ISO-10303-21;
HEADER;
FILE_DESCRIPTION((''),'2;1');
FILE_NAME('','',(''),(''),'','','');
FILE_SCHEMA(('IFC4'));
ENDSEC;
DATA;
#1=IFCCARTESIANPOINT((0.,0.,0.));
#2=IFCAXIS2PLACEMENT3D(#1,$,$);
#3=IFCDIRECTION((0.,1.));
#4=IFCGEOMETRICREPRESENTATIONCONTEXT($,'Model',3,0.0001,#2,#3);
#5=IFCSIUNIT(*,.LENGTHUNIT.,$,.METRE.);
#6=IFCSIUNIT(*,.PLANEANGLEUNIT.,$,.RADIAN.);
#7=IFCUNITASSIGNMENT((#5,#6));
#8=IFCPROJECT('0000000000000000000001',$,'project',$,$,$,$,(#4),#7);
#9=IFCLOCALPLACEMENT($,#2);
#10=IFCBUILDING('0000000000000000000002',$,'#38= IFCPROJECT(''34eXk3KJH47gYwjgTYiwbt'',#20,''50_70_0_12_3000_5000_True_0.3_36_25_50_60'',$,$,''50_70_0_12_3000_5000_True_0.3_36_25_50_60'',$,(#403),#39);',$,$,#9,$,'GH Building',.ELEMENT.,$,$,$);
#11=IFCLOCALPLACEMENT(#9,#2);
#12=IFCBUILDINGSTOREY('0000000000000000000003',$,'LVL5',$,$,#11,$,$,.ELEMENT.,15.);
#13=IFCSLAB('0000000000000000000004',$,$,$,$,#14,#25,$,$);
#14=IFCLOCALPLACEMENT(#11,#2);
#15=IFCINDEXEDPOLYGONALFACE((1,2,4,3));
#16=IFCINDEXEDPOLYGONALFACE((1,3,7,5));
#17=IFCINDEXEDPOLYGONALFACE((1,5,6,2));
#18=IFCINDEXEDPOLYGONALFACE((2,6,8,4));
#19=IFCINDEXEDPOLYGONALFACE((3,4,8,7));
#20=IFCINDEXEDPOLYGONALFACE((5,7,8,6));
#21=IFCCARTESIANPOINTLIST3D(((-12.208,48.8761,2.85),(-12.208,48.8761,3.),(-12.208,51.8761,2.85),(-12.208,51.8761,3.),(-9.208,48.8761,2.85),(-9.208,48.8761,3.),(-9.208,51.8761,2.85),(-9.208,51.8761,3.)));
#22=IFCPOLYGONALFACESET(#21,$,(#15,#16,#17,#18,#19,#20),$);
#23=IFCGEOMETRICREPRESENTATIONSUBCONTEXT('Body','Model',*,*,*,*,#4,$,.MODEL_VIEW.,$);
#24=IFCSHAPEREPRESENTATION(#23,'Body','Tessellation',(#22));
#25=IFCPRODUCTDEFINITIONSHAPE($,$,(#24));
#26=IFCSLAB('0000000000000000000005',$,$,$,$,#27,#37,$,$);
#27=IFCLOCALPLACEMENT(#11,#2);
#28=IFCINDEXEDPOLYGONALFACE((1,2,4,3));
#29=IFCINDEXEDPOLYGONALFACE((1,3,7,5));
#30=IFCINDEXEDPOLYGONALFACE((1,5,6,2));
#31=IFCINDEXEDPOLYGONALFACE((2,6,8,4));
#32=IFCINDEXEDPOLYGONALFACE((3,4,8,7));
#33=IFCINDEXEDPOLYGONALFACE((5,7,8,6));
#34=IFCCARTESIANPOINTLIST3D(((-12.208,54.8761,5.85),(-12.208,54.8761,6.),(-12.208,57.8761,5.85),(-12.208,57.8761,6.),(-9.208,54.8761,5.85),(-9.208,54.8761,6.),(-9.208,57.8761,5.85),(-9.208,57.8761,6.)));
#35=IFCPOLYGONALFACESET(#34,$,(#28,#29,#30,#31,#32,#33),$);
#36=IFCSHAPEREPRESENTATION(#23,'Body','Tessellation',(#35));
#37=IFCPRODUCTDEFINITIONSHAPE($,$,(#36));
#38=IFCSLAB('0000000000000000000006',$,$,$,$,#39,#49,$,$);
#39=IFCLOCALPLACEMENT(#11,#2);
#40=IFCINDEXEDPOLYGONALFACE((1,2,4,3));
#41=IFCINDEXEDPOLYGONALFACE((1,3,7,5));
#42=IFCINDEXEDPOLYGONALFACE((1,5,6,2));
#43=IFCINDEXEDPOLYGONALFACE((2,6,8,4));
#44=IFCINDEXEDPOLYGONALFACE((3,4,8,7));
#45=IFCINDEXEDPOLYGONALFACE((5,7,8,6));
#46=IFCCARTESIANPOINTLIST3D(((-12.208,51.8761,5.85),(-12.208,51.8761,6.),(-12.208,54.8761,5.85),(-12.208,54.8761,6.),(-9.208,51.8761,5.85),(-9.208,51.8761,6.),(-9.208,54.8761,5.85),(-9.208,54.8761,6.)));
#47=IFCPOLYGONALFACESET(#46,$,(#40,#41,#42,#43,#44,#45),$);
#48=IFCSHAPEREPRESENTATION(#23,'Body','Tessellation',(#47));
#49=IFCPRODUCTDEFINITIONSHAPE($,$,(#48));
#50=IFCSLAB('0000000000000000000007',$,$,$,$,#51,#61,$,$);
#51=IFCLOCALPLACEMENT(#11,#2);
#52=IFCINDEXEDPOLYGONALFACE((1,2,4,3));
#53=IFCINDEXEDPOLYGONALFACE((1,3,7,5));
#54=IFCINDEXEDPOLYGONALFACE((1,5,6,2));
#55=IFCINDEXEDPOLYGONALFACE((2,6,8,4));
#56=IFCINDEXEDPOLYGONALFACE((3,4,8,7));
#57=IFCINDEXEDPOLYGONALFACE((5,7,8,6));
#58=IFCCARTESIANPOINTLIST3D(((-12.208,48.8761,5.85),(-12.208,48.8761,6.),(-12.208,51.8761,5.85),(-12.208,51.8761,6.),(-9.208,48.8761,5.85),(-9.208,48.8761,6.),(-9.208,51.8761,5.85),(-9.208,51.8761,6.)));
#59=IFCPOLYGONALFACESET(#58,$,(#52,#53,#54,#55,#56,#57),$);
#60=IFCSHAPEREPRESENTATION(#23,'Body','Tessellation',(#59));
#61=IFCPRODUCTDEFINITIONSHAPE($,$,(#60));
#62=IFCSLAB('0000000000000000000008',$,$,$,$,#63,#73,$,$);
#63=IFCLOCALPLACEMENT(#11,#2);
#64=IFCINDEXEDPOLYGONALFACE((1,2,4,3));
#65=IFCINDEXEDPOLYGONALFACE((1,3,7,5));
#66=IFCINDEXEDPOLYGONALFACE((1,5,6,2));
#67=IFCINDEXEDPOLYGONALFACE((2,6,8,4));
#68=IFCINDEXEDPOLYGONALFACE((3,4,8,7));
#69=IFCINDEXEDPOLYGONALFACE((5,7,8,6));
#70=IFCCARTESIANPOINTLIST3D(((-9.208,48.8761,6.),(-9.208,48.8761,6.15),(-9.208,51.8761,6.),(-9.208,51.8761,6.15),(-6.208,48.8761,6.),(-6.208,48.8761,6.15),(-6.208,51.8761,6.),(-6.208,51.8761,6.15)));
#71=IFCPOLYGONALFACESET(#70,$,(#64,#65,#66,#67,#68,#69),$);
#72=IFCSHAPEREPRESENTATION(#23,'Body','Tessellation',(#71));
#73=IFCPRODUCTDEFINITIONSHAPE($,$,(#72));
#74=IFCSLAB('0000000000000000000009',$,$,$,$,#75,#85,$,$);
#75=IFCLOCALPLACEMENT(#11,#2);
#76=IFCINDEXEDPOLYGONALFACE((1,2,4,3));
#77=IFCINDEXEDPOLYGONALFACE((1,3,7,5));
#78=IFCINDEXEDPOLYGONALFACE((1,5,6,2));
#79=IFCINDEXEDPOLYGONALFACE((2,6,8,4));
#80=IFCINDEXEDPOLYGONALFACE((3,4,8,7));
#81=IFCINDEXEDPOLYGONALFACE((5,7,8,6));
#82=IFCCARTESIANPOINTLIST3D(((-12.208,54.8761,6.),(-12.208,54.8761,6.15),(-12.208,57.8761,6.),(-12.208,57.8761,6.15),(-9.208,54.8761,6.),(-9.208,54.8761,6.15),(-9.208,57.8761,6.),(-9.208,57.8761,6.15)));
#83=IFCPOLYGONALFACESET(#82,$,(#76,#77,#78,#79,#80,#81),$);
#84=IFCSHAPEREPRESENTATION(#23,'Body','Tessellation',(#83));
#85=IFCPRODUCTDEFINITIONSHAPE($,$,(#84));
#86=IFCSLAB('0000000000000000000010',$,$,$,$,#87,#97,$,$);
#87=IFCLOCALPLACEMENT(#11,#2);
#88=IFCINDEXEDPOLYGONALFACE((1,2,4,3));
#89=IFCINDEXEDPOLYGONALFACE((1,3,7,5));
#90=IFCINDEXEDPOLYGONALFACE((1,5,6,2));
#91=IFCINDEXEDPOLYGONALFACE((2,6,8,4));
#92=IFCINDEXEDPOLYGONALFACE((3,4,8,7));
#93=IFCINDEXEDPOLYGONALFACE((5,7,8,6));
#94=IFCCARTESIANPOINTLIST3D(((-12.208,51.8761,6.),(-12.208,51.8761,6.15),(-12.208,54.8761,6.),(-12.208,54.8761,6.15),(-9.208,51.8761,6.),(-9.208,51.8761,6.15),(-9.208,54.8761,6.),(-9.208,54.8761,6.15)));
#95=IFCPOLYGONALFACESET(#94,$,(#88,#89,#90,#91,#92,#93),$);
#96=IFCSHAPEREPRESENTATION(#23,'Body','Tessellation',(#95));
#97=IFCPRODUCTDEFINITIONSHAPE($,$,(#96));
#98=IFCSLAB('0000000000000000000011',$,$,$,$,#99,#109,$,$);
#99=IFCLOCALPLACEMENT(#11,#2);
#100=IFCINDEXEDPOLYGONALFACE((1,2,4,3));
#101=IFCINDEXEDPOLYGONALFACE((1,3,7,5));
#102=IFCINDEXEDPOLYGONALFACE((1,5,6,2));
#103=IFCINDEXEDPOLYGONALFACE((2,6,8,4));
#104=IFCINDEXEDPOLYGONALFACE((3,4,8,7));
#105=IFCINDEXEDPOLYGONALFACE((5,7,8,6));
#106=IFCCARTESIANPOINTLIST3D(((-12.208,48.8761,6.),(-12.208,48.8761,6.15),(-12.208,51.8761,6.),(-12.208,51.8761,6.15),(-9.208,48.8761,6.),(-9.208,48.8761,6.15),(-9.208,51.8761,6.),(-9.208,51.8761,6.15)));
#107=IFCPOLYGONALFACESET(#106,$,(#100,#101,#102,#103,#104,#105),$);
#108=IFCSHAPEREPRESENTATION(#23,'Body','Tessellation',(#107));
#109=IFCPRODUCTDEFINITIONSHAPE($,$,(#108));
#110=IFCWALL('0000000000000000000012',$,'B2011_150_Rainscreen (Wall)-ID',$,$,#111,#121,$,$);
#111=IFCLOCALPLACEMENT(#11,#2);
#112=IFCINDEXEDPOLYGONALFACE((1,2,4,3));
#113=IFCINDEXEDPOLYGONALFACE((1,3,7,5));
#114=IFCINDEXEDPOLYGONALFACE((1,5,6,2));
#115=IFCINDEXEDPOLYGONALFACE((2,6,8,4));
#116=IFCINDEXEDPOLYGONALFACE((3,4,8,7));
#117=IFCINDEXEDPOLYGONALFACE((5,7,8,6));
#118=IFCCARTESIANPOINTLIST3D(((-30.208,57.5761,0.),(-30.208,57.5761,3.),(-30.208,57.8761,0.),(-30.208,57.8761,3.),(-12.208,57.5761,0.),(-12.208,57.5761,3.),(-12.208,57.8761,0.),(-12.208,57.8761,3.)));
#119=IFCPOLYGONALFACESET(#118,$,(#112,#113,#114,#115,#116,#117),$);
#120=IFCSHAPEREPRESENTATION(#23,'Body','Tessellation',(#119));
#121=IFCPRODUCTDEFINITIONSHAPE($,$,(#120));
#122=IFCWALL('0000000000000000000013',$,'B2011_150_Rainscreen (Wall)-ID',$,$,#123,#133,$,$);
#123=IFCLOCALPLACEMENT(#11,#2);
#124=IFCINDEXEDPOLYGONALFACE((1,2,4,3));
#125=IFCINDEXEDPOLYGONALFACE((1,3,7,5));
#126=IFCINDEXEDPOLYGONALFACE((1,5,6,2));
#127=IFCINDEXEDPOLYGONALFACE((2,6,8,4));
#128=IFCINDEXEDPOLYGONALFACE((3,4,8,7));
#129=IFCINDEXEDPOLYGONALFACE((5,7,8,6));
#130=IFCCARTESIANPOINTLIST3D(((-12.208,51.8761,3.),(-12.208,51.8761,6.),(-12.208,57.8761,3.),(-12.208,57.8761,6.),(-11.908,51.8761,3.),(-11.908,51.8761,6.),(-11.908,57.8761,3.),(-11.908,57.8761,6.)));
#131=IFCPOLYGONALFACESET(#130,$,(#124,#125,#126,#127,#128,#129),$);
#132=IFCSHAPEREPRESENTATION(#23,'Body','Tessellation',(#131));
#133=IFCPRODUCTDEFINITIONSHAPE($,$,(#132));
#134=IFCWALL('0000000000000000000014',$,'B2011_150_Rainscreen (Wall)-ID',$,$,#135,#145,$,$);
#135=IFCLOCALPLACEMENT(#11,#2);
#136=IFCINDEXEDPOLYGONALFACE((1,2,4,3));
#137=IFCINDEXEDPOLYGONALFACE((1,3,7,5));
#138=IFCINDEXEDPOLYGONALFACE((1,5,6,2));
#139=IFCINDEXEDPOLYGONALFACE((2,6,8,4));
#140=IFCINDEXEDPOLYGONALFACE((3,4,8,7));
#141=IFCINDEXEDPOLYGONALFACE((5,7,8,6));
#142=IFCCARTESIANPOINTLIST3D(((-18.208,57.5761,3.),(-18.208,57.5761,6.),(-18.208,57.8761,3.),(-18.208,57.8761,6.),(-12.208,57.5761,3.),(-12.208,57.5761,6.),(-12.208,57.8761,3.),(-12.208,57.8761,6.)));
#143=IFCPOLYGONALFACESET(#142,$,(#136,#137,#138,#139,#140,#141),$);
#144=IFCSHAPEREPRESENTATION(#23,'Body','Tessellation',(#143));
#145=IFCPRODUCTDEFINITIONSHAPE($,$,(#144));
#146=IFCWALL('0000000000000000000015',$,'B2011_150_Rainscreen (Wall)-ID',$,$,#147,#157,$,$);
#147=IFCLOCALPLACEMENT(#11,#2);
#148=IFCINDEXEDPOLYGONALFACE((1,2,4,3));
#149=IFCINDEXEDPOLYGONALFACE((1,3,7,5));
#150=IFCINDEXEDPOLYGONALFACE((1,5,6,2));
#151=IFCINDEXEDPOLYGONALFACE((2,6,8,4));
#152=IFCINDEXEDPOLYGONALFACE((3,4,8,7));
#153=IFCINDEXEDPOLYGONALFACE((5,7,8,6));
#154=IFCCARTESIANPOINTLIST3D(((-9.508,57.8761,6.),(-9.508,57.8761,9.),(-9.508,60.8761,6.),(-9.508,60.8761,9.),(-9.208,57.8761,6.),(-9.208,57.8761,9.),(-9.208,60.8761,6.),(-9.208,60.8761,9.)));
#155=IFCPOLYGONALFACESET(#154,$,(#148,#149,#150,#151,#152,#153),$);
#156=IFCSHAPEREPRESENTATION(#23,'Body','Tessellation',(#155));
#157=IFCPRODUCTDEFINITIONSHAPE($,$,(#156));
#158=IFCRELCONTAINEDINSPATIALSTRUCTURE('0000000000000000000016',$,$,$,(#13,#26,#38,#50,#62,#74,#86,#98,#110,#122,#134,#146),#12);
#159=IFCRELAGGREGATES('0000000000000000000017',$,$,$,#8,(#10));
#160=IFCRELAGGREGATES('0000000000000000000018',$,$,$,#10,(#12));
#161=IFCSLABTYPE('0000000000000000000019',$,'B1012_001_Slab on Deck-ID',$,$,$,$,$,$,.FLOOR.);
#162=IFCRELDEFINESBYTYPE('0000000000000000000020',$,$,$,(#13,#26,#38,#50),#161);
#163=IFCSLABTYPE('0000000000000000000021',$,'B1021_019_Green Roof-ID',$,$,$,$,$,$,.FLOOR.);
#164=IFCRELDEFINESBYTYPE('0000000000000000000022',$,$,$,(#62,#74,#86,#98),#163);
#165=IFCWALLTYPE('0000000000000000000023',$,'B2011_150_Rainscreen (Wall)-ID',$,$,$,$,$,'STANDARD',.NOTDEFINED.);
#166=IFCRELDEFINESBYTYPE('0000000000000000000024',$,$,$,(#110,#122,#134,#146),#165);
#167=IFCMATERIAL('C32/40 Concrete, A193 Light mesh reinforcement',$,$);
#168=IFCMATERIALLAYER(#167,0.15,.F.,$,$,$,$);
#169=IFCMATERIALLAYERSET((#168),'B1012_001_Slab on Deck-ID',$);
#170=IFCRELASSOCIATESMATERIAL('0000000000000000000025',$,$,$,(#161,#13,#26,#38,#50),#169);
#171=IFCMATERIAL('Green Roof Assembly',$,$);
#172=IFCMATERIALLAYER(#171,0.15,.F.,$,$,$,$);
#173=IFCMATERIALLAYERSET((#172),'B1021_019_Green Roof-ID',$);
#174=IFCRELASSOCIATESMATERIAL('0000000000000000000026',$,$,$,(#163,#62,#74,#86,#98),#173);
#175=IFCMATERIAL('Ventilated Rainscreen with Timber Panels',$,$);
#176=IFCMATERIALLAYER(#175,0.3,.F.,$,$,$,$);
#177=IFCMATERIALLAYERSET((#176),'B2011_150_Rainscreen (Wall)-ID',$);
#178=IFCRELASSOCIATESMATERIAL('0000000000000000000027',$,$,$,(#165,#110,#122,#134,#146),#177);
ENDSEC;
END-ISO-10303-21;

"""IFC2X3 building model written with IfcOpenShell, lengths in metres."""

from ifc_helpers import new_model, si_unit, direction, frame, frame_2d, origin, place, context, subcontext, project, spatial, polyline, rectangle, outline, extrude, material, layer, layer_set, layer_usage, type_object, element, save


model = new_model("IFC2X3")

# Units and contexts
model_context = context("Model", 3, precision=0.0001, world=origin(), true_north=direction((0.0, 1.0)))
body_context = subcontext(model_context, "Body", "Model", "MODEL_VIEW")
ifc_project = project(units=[si_unit("LENGTHUNIT", "METRE"), si_unit("PLANEANGLEUNIT", "RADIAN")], contexts=[model_context])

# Building, storey
building_placement = place(None, origin())
building = spatial("IfcBuilding", under=ifc_project, at=building_placement, Name="#38= IFCPROJECT('34eXk3KJH47gYwjgTYiwbt',#20,'50_70_0_12_3000_5000_True_0.3_36_25_50_60',$,$,'50_70_0_12_3000_5000_True_0.3_36_25_50_60',$,(#403),#39);", LongName="GH Building", CompositionType="ELEMENT")
storey_placement = place(building_placement, origin())
storey = spatial("IfcBuildingStorey", under=building, at=storey_placement, Name="LVL5", CompositionType="ELEMENT", Elevation=15.0)

# Slabs
ifc_material_1 = material(Name="C32/40 Concrete, A193 Light mesh reinforcement")
ifc_layer_1 = layer(ifc_material_1, 0.15, ventilated=False)
ifc_layer_set_1 = layer_set([ifc_layer_1], Name="B1012_001_Slab on Deck-ID")
slab_type_1 = type_object("IfcSlabType", Name="B1012_001_Slab on Deck-ID", PredefinedType="FLOOR", material=ifc_layer_set_1)
ifc_layer_usage_1 = layer_usage(ifc_layer_set_1, "AXIS3", "NEGATIVE", -0.15)
slab_1_placement = place(storey_placement, frame((-10.708, 50.3761, 2.85), z_axis=(0.0, 0.0, 1.0), x_axis=(0.0, -1.0, 0.0)))
element("IfcSlab", 1, at=slab_1_placement, inside=storey, type_object=slab_type_1, material=ifc_layer_usage_1, context=body_context, shape_type="SweptSolid", body=[
    extrude(outline(polyline([(-1.5, -1.5), (1.5, -1.5), (1.5, 1.5), (-1.5, 1.5), (-1.5, -1.5)])), origin(), (0.0, 0.0, 1.0), 0.15),
])
ifc_layer_usage_2 = layer_usage(ifc_layer_set_1, "AXIS3", "NEGATIVE", -0.15)
slab_2_placement = place(storey_placement, frame((-10.708, 56.3761, 5.85)))
element("IfcSlab", 2, at=slab_2_placement, inside=storey, type_object=slab_type_1, material=ifc_layer_usage_2, context=body_context, shape_type="SweptSolid", body=[
    extrude(outline(polyline([(-1.5, 1.5), (1.5, 1.5), (1.5, -1.5), (-1.5, -1.5), (-1.5, 1.5)])), origin(), (0.0, 0.0, 1.0), 0.15),
])
ifc_layer_usage_3 = layer_usage(ifc_layer_set_1, "AXIS3", "NEGATIVE", -0.15)
slab_3_placement = place(storey_placement, frame((-10.708, 53.3761, 5.85)))
element("IfcSlab", 3, at=slab_3_placement, inside=storey, type_object=slab_type_1, material=ifc_layer_usage_3, context=body_context, shape_type="SweptSolid", body=[
    extrude(outline(polyline([(1.5, 1.5), (1.5, -1.5), (-1.5, -1.5), (-1.5, 1.5), (1.5, 1.5)])), origin(), (0.0, 0.0, 1.0), 0.15),
])
ifc_layer_usage_4 = layer_usage(ifc_layer_set_1, "AXIS3", "NEGATIVE", -0.15)
slab_4_placement = place(storey_placement, frame((-10.708, 50.3761, 5.85)))
element("IfcSlab", 4, at=slab_4_placement, inside=storey, type_object=slab_type_1, material=ifc_layer_usage_4, context=body_context, shape_type="SweptSolid", body=[
    extrude(outline(polyline([(1.5, 1.5), (1.5, -1.5), (-1.5, -1.5), (-1.5, 1.5), (1.5, 1.5)])), origin(), (0.0, 0.0, 1.0), 0.15),
])
ifc_material_2 = material(Name="Green Roof Assembly")
ifc_layer_2 = layer(ifc_material_2, 0.15, ventilated=False)
ifc_layer_set_2 = layer_set([ifc_layer_2], Name="B1021_019_Green Roof-ID")
ifc_layer_usage_5 = layer_usage(ifc_layer_set_2, "AXIS3", "NEGATIVE", -0.15)
slab_type_2 = type_object("IfcSlabType", Name="B1021_019_Green Roof-ID", PredefinedType="FLOOR", material=ifc_layer_set_2)
slab_5_placement = place(storey_placement, frame((-7.708, 50.3761, 6.0)))
element("IfcSlab", 5, at=slab_5_placement, inside=storey, type_object=slab_type_2, material=ifc_layer_usage_5, context=body_context, shape_type="SweptSolid", body=[
    extrude(outline(polyline([(1.5, -1.5), (-1.5, -1.5), (-1.5, 1.5), (1.5, 1.5), (1.5, -1.5)])), origin(), (0.0, 0.0, 1.0), 0.15),
])
ifc_layer_usage_6 = layer_usage(ifc_layer_set_2, "AXIS3", "NEGATIVE", -0.15)
slab_6_placement = place(storey_placement, frame((-10.708, 56.3761, 6.0)))
element("IfcSlab", 6, at=slab_6_placement, inside=storey, type_object=slab_type_2, material=ifc_layer_usage_6, context=body_context, shape_type="SweptSolid", body=[
    extrude(outline(polyline([(-1.5, 1.5), (1.5, 1.5), (1.5, -1.5), (-1.5, -1.5), (-1.5, 1.5)])), origin(), (0.0, 0.0, 1.0), 0.15),
])
ifc_layer_usage_7 = layer_usage(ifc_layer_set_2, "AXIS3", "NEGATIVE", -0.15)
slab_7_placement = place(storey_placement, frame((-10.708, 53.3761, 6.0)))
element("IfcSlab", 7, at=slab_7_placement, inside=storey, type_object=slab_type_2, material=ifc_layer_usage_7, context=body_context, shape_type="SweptSolid", body=[
    extrude(outline(polyline([(1.5, 1.5), (1.5, -1.5), (-1.5, -1.5), (-1.5, 1.5), (1.5, 1.5)])), origin(), (0.0, 0.0, 1.0), 0.15),
])
ifc_layer_usage_8 = layer_usage(ifc_layer_set_2, "AXIS3", "NEGATIVE", -0.15)
slab_8_placement = place(storey_placement, frame((-10.708, 50.3761, 6.0)))
element("IfcSlab", 8, at=slab_8_placement, inside=storey, type_object=slab_type_2, material=ifc_layer_usage_8, context=body_context, shape_type="SweptSolid", body=[
    extrude(outline(polyline([(1.5, 1.5), (1.5, -1.5), (-1.5, -1.5), (-1.5, 1.5), (1.5, 1.5)])), origin(), (0.0, 0.0, 1.0), 0.15),
])

# Walls
ifc_material_3 = material(Name="Ventilated Rainscreen with Timber Panels")
ifc_layer_3 = layer(ifc_material_3, 0.3, ventilated=False)
ifc_layer_set_3 = layer_set([ifc_layer_3], Name="B2011_150_Rainscreen (Wall)-ID")
ifc_layer_usage_9 = layer_usage(ifc_layer_set_3, "AXIS2", "POSITIVE", 0.0)
wall_type = type_object("IfcWallType", Name="B2011_150_Rainscreen (Wall)-ID", ElementType="STANDARD", PredefinedType="NOTDEFINED", material=ifc_layer_set_3)
wall_1_placement = place(storey_placement, frame((-12.208, 57.8761, 0.0), z_axis=(0.0, 0.0, 1.0), x_axis=(-1.0, 0.0, 0.0)))
element("IfcWall", 9, at=wall_1_placement, inside=storey, type_object=wall_type, material=ifc_layer_usage_9, Name="B2011_150_Rainscreen (Wall)-ID", context=body_context, shape_type="SweptSolid", body=[
    extrude(rectangle(XDim=18.0, YDim=0.3, at=frame_2d((9.0, 0.15))), origin(), (0.0, 0.0, 1.0), 3.0),
])
ifc_layer_usage_10 = layer_usage(ifc_layer_set_3, "AXIS2", "POSITIVE", 0.0)
wall_2_placement = place(storey_placement, frame((-12.208, 57.8761, 3.0), z_axis=(0.0, 0.0, 1.0), x_axis=(0.0, -1.0, 0.0)))
element("IfcWall", 10, at=wall_2_placement, inside=storey, type_object=wall_type, material=ifc_layer_usage_10, Name="B2011_150_Rainscreen (Wall)-ID", context=body_context, shape_type="SweptSolid", body=[
    extrude(rectangle(XDim=6.0, YDim=0.3, at=frame_2d((3.0, 0.15))), origin(), (0.0, 0.0, 1.0), 3.0),
])
ifc_layer_usage_11 = layer_usage(ifc_layer_set_3, "AXIS2", "POSITIVE", 0.0)
wall_3_placement = place(storey_placement, frame((-12.208, 57.8761, 3.0), z_axis=(0.0, 0.0, 1.0), x_axis=(-1.0, 0.0, 0.0)))
element("IfcWall", 11, at=wall_3_placement, inside=storey, type_object=wall_type, material=ifc_layer_usage_11, Name="B2011_150_Rainscreen (Wall)-ID", context=body_context, shape_type="SweptSolid", body=[
    extrude(rectangle(XDim=6.0, YDim=0.3, at=frame_2d((3.0, 0.15))), origin(), (0.0, 0.0, 1.0), 3.0),
])
ifc_layer_usage_12 = layer_usage(ifc_layer_set_3, "AXIS2", "POSITIVE", 0.0)
wall_4_placement = place(storey_placement, frame((-9.208, 57.8761, 6.0), z_axis=(0.0, 0.0, 1.0), x_axis=(0.0, 1.0, 0.0)))
element("IfcWall", 12, at=wall_4_placement, inside=storey, type_object=wall_type, material=ifc_layer_usage_12, Name="B2011_150_Rainscreen (Wall)-ID", context=body_context, shape_type="SweptSolid", body=[
    extrude(rectangle(XDim=3.0, YDim=0.3, at=frame_2d((1.5, 0.15))), origin(), (0.0, 0.0, 1.0), 3.0),
])

save(model, "model.ifc")
